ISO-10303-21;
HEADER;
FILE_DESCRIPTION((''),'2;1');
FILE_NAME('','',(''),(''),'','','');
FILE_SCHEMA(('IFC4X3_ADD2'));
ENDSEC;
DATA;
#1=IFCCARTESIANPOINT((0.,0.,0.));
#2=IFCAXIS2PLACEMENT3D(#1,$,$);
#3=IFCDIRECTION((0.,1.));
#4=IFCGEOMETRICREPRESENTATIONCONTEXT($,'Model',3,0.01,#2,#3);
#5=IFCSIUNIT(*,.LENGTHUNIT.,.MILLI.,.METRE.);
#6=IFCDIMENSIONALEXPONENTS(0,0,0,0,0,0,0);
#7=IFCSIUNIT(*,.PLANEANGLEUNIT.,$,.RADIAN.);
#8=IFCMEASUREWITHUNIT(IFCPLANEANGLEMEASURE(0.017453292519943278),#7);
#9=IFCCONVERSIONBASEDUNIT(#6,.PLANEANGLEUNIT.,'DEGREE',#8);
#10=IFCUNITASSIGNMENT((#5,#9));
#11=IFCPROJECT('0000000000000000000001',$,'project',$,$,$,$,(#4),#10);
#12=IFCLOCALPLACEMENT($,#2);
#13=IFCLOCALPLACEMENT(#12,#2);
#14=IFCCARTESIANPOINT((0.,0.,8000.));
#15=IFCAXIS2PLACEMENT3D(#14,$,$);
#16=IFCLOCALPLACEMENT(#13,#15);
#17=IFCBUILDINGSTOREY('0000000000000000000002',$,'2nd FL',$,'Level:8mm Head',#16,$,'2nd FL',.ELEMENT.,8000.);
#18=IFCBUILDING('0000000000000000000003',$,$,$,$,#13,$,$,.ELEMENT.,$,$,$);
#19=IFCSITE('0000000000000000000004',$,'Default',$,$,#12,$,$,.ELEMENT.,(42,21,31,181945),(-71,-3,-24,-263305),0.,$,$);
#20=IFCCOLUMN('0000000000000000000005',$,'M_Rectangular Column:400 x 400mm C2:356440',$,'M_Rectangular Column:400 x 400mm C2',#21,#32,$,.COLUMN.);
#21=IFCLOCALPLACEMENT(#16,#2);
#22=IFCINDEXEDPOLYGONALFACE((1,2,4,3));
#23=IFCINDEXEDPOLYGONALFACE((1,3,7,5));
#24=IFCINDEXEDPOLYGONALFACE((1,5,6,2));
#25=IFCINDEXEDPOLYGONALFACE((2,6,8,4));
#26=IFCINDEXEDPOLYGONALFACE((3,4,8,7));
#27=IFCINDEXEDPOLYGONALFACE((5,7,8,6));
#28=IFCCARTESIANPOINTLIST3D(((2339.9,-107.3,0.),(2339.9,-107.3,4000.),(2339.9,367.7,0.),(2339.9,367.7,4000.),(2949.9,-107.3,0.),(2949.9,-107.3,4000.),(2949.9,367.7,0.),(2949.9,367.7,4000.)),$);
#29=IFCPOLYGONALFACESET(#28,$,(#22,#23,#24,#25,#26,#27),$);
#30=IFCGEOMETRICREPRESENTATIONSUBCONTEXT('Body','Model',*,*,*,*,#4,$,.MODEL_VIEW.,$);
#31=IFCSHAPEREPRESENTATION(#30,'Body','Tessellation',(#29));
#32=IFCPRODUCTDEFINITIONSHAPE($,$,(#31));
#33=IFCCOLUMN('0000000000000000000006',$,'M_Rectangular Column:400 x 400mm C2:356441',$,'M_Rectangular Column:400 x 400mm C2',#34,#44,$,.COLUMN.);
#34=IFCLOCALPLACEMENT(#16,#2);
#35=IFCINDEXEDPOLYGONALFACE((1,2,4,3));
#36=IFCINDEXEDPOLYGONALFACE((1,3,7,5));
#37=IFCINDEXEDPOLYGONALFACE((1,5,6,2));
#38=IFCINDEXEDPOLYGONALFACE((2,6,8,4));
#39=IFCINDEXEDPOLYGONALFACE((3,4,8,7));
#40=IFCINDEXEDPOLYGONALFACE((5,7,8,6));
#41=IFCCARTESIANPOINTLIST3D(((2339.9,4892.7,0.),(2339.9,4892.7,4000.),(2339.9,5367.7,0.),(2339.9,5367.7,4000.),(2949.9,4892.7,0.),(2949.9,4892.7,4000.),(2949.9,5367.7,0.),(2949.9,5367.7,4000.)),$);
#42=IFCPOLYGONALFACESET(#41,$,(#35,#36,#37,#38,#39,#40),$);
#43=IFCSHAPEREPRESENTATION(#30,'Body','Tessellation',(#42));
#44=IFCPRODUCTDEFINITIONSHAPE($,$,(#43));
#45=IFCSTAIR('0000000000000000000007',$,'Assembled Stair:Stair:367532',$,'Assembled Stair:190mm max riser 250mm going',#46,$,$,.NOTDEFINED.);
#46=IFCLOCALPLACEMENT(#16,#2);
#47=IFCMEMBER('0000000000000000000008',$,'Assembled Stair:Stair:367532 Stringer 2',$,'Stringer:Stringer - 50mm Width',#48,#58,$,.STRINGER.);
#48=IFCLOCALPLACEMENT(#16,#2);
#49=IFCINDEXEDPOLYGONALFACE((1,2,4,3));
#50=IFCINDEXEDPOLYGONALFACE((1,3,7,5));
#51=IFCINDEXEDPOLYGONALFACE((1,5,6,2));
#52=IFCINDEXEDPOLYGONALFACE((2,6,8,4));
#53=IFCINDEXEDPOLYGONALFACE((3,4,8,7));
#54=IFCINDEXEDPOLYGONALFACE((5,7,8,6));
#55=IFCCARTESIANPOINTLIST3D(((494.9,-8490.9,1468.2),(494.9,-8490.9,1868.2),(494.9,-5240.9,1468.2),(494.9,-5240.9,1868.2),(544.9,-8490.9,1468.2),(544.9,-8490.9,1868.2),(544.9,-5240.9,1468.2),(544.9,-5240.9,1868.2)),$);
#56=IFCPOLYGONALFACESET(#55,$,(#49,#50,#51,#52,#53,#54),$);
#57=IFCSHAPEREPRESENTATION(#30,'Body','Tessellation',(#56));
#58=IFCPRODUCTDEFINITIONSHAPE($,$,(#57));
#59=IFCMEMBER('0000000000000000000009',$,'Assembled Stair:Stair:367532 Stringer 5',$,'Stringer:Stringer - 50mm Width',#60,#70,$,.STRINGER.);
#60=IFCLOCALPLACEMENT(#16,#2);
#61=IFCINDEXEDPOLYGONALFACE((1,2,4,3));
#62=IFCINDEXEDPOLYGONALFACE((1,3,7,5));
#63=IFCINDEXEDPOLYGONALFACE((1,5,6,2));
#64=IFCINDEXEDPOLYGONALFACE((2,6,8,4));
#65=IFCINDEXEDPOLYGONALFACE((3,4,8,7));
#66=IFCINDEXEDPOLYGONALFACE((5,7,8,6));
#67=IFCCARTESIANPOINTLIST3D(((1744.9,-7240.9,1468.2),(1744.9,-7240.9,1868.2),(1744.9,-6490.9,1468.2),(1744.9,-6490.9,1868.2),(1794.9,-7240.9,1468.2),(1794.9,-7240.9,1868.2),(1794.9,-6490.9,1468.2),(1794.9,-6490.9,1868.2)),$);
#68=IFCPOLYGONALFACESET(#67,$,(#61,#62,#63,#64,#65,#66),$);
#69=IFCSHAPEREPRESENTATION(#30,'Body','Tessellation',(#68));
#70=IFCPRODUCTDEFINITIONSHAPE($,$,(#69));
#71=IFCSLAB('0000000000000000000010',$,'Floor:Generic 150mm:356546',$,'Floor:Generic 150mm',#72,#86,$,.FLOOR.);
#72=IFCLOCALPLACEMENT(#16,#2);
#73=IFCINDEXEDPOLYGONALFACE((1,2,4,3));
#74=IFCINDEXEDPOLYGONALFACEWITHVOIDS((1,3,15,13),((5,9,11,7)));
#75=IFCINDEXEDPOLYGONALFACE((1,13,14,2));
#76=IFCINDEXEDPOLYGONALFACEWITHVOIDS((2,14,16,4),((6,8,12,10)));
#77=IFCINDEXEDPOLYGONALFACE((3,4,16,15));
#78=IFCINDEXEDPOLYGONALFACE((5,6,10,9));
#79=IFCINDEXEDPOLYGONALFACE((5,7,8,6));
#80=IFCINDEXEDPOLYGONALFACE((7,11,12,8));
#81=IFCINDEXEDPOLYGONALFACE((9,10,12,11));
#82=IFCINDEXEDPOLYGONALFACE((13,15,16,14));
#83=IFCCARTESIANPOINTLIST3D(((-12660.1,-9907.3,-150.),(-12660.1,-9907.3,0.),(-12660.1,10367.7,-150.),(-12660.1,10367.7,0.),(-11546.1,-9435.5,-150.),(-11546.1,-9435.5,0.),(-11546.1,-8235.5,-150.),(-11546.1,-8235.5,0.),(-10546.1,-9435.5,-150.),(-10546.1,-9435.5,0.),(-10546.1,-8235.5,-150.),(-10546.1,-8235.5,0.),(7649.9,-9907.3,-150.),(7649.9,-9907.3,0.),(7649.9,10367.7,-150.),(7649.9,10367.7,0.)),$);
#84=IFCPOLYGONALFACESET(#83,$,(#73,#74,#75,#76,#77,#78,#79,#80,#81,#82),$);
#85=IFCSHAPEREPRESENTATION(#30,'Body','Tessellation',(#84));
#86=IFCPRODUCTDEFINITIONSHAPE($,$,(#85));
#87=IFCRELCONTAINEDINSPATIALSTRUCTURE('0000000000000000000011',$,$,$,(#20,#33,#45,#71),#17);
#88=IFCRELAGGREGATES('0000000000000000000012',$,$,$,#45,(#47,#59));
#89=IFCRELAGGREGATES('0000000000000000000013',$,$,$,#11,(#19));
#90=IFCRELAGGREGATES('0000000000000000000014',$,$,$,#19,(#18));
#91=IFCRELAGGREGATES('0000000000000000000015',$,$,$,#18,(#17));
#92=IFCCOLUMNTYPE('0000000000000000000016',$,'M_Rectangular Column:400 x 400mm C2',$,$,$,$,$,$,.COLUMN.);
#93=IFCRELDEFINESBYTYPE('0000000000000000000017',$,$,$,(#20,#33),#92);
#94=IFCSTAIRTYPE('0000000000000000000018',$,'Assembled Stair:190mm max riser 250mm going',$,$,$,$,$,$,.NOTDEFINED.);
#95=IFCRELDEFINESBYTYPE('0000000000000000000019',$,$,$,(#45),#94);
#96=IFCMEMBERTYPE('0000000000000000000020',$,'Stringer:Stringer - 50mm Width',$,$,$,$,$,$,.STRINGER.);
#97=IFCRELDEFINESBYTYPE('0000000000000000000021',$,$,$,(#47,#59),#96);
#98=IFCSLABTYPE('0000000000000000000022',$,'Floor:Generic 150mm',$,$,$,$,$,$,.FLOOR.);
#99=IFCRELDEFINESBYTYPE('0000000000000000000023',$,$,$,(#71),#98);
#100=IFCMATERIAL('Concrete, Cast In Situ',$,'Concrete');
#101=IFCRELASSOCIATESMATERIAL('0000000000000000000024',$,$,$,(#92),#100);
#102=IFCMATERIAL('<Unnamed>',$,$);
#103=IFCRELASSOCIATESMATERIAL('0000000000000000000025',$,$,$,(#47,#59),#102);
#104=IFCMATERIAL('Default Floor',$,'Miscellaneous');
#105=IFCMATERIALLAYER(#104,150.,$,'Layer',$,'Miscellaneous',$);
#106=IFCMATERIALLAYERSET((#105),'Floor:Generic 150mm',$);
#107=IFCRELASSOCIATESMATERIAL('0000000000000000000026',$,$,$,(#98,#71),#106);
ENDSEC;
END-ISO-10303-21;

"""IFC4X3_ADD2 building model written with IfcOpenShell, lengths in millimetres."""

from ifc_helpers import new_model, entity, si_unit, converted_unit, direction, frame, frame_2d, origin, origin_2d_with_axis, place, context, subcontext, project, spatial, rectangle, extrude, boolean, source, transform, mapped, material, layer, layer_set, layer_usage, material_profile, profile_set, type_object, type_shapes, element, aggregate, save


model = new_model("IFC4X3_ADD2")

# Units and contexts
model_context = context("Model", 3, precision=0.01, world=origin(), true_north=direction((0.0, 1.0)))
body_context = subcontext(model_context, "Body", "Model", "MODEL_VIEW")
ifc_project = project(units=[si_unit("LENGTHUNIT", "METRE", prefix="MILLI"), converted_unit("PLANEANGLEUNIT", "DEGREE", entity("IfcPlaneAngleMeasure", 0.017453292519943278), si_unit("PLANEANGLEUNIT", "RADIAN"), dimensions=[0, 0, 0, 0, 0, 0, 0])], contexts=[model_context])

# Site, building, storey
site_placement = place(None, origin())
site = spatial("IfcSite", under=ifc_project, at=site_placement, Name="Default", CompositionType="ELEMENT", RefLatitude=(42, 21, 31, 181945), RefLongitude=(-71, -3, -24, -263305), RefElevation=0.0)
building_placement = place(site_placement, origin())
building = spatial("IfcBuilding", under=site, at=building_placement, CompositionType="ELEMENT")
storey_placement = place(building_placement, frame((0.0, 0.0, 8000.0)))
storey = spatial("IfcBuildingStorey", under=building, at=storey_placement, Name="2nd FL", ObjectType="Level:8mm Head", LongName="2nd FL", CompositionType="ELEMENT", Elevation=8000.0)

# Columns
ifc_material_1 = material(Name="Concrete, Cast In Situ", Category="Concrete")
ifc_material_profile_1 = material_profile(ifc_material_1, rectangle(XDim=610.0, YDim=475.0, at=origin_2d_with_axis()), Name="400 x 400mm C2")
ifc_profile_set_1 = profile_set([ifc_material_profile_1], Name="400 x 400mm C2")
column_type_1 = type_object("IfcColumnType", Name="M_Rectangular Column:400 x 400mm C2", PredefinedType="COLUMN", material=ifc_profile_set_1)
shared_shape_1 = source(origin(), body_context, "Body", "SweptSolid", [
    extrude(rectangle(XDim=610.0, YDim=475.0, at=origin_2d_with_axis()), frame((0.0, 0.0, 8000.0), z_axis=(0.0, 0.0, 1.0), x_axis=(-1.0, 0.0, 0.0)), (0.0, 0.0, 1.0), 4000.0),
])
type_shapes(column_type_1, [shared_shape_1])
for number, where, name in (
    (1, (2644.9, 130.2, -8000.0), "M_Rectangular Column:400 x 400mm C2:356440"),
    (2, (2644.9, 5130.2, -8000.0), "M_Rectangular Column:400 x 400mm C2:356441"),
):
    element("IfcColumn", number, at=place(storey_placement, frame(where)), inside=storey, type_object=column_type_1, Name=name, ObjectType="M_Rectangular Column:400 x 400mm C2", PredefinedType="COLUMN", context=body_context, shape_type="MappedRepresentation", body=[
        mapped(shared_shape_1, transform((0.0, 0.0, 0.0), scale=1.0)),
    ])

# Stair, members
stair_type = type_object("IfcStairType", Name="Assembled Stair:190mm max riser 250mm going", PredefinedType="NOTDEFINED")
stair_placement = place(storey_placement, origin())
stair = element("IfcStair", 3, at=stair_placement, inside=storey, type_object=stair_type, Name="Assembled Stair:Stair:367532", ObjectType="Assembled Stair:190mm max riser 250mm going", PredefinedType="NOTDEFINED")
ifc_material_2 = material(Name="<Unnamed>")
member_type = type_object("IfcMemberType", Name="Stringer:Stringer - 50mm Width", PredefinedType="STRINGER")
member_1_placement = place(stair_placement, frame((494.9, -8490.9, 1468.2)))
member_1 = element("IfcMember", 4, at=member_1_placement, type_object=member_type, material=ifc_material_2, Name="Assembled Stair:Stair:367532 Stringer 2", ObjectType="Stringer:Stringer - 50mm Width", PredefinedType="STRINGER", context=body_context, shape_type="SweptSolid", body=[
    extrude(rectangle(XDim=3250.0, YDim=50.0, at=origin_2d_with_axis()), frame((25.0, 1625.0, 0.0), z_axis=(0.0, 0.0, 1.0), x_axis=(0.0, 1.0, 0.0)), (0.0, 0.0, 1.0), 400.0),
])
member_2_placement = place(stair_placement, frame((1744.9, -7240.9, 1468.2)))
member_2 = element("IfcMember", 5, at=member_2_placement, type_object=member_type, material=ifc_material_2, Name="Assembled Stair:Stair:367532 Stringer 5", ObjectType="Stringer:Stringer - 50mm Width", PredefinedType="STRINGER", context=body_context, shape_type="SweptSolid", body=[
    extrude(rectangle(XDim=750.0, YDim=50.0, at=frame_2d((0.0, 0.0), x_axis=(1.0, 0.0))), frame((25.0, 375.0, 0.0), z_axis=(0.0, 0.0, 1.0), x_axis=(0.0, 1.0, 0.0)), (0.0, 0.0, 1.0), 400.0),
])

# Slab, opening
ifc_material_3 = material(Name="Default Floor", Category="Miscellaneous")
ifc_layer = layer(ifc_material_3, 150.0, Name="Layer", Category="Miscellaneous")
ifc_layer_set = layer_set([ifc_layer], Name="Floor:Generic 150mm")
ifc_layer_usage = layer_usage(ifc_layer_set, "AXIS3", "POSITIVE", 0.0)
slab_type = type_object("IfcSlabType", Name="Floor:Generic 150mm", PredefinedType="FLOOR", material=ifc_layer_set)
slab_placement = place(storey_placement, origin())
slab = element("IfcSlab", 6, at=slab_placement, inside=storey, type_object=slab_type, material=ifc_layer_usage, Name="Floor:Generic 150mm:356546", ObjectType="Floor:Generic 150mm", PredefinedType="FLOOR", context=body_context, shape_type="SweptSolid", body=[
    boolean("DIFFERENCE", extrude(rectangle(XDim=20275.0, YDim=20310.0, at=origin_2d_with_axis()), frame((-2505.1, 230.2, 0.0), z_axis=(0.0, 0.0, -1.0), x_axis=(0.0, 1.0, 0.0)), (0.0, 0.0, 1.0), 150.0), extrude(rectangle(XDim=1200.0, YDim=1000.0, at=frame_2d((0.0, 0.0), x_axis=(1.0, 0.0))), frame((-11046.1, -8835.5, 0.0), z_axis=(0.0, 0.0, -1.0), x_axis=(0.0, -1.0, 0.0)), (0.0, 0.0, 1.0), 150.0)),
])
opening_placement = place(slab_placement, origin())
element("IfcOpeningElement", 7, at=opening_placement, cuts=slab, PredefinedType="OPENING", context=body_context, shape_type="SweptSolid", body=[
    extrude(rectangle(XDim=1200.0, YDim=1000.0, at=frame_2d((0.0, 0.0), x_axis=(1.0, 0.0))), frame((-11046.1, -8835.5, -150.0), z_axis=(0.0, 0.0, 1.0), x_axis=(0.0, 1.0, 0.0)), (0.0, 0.0, 1.0), 150.0),
])

aggregate(stair, [member_1, member_2])

save(model, "model.ifc")
